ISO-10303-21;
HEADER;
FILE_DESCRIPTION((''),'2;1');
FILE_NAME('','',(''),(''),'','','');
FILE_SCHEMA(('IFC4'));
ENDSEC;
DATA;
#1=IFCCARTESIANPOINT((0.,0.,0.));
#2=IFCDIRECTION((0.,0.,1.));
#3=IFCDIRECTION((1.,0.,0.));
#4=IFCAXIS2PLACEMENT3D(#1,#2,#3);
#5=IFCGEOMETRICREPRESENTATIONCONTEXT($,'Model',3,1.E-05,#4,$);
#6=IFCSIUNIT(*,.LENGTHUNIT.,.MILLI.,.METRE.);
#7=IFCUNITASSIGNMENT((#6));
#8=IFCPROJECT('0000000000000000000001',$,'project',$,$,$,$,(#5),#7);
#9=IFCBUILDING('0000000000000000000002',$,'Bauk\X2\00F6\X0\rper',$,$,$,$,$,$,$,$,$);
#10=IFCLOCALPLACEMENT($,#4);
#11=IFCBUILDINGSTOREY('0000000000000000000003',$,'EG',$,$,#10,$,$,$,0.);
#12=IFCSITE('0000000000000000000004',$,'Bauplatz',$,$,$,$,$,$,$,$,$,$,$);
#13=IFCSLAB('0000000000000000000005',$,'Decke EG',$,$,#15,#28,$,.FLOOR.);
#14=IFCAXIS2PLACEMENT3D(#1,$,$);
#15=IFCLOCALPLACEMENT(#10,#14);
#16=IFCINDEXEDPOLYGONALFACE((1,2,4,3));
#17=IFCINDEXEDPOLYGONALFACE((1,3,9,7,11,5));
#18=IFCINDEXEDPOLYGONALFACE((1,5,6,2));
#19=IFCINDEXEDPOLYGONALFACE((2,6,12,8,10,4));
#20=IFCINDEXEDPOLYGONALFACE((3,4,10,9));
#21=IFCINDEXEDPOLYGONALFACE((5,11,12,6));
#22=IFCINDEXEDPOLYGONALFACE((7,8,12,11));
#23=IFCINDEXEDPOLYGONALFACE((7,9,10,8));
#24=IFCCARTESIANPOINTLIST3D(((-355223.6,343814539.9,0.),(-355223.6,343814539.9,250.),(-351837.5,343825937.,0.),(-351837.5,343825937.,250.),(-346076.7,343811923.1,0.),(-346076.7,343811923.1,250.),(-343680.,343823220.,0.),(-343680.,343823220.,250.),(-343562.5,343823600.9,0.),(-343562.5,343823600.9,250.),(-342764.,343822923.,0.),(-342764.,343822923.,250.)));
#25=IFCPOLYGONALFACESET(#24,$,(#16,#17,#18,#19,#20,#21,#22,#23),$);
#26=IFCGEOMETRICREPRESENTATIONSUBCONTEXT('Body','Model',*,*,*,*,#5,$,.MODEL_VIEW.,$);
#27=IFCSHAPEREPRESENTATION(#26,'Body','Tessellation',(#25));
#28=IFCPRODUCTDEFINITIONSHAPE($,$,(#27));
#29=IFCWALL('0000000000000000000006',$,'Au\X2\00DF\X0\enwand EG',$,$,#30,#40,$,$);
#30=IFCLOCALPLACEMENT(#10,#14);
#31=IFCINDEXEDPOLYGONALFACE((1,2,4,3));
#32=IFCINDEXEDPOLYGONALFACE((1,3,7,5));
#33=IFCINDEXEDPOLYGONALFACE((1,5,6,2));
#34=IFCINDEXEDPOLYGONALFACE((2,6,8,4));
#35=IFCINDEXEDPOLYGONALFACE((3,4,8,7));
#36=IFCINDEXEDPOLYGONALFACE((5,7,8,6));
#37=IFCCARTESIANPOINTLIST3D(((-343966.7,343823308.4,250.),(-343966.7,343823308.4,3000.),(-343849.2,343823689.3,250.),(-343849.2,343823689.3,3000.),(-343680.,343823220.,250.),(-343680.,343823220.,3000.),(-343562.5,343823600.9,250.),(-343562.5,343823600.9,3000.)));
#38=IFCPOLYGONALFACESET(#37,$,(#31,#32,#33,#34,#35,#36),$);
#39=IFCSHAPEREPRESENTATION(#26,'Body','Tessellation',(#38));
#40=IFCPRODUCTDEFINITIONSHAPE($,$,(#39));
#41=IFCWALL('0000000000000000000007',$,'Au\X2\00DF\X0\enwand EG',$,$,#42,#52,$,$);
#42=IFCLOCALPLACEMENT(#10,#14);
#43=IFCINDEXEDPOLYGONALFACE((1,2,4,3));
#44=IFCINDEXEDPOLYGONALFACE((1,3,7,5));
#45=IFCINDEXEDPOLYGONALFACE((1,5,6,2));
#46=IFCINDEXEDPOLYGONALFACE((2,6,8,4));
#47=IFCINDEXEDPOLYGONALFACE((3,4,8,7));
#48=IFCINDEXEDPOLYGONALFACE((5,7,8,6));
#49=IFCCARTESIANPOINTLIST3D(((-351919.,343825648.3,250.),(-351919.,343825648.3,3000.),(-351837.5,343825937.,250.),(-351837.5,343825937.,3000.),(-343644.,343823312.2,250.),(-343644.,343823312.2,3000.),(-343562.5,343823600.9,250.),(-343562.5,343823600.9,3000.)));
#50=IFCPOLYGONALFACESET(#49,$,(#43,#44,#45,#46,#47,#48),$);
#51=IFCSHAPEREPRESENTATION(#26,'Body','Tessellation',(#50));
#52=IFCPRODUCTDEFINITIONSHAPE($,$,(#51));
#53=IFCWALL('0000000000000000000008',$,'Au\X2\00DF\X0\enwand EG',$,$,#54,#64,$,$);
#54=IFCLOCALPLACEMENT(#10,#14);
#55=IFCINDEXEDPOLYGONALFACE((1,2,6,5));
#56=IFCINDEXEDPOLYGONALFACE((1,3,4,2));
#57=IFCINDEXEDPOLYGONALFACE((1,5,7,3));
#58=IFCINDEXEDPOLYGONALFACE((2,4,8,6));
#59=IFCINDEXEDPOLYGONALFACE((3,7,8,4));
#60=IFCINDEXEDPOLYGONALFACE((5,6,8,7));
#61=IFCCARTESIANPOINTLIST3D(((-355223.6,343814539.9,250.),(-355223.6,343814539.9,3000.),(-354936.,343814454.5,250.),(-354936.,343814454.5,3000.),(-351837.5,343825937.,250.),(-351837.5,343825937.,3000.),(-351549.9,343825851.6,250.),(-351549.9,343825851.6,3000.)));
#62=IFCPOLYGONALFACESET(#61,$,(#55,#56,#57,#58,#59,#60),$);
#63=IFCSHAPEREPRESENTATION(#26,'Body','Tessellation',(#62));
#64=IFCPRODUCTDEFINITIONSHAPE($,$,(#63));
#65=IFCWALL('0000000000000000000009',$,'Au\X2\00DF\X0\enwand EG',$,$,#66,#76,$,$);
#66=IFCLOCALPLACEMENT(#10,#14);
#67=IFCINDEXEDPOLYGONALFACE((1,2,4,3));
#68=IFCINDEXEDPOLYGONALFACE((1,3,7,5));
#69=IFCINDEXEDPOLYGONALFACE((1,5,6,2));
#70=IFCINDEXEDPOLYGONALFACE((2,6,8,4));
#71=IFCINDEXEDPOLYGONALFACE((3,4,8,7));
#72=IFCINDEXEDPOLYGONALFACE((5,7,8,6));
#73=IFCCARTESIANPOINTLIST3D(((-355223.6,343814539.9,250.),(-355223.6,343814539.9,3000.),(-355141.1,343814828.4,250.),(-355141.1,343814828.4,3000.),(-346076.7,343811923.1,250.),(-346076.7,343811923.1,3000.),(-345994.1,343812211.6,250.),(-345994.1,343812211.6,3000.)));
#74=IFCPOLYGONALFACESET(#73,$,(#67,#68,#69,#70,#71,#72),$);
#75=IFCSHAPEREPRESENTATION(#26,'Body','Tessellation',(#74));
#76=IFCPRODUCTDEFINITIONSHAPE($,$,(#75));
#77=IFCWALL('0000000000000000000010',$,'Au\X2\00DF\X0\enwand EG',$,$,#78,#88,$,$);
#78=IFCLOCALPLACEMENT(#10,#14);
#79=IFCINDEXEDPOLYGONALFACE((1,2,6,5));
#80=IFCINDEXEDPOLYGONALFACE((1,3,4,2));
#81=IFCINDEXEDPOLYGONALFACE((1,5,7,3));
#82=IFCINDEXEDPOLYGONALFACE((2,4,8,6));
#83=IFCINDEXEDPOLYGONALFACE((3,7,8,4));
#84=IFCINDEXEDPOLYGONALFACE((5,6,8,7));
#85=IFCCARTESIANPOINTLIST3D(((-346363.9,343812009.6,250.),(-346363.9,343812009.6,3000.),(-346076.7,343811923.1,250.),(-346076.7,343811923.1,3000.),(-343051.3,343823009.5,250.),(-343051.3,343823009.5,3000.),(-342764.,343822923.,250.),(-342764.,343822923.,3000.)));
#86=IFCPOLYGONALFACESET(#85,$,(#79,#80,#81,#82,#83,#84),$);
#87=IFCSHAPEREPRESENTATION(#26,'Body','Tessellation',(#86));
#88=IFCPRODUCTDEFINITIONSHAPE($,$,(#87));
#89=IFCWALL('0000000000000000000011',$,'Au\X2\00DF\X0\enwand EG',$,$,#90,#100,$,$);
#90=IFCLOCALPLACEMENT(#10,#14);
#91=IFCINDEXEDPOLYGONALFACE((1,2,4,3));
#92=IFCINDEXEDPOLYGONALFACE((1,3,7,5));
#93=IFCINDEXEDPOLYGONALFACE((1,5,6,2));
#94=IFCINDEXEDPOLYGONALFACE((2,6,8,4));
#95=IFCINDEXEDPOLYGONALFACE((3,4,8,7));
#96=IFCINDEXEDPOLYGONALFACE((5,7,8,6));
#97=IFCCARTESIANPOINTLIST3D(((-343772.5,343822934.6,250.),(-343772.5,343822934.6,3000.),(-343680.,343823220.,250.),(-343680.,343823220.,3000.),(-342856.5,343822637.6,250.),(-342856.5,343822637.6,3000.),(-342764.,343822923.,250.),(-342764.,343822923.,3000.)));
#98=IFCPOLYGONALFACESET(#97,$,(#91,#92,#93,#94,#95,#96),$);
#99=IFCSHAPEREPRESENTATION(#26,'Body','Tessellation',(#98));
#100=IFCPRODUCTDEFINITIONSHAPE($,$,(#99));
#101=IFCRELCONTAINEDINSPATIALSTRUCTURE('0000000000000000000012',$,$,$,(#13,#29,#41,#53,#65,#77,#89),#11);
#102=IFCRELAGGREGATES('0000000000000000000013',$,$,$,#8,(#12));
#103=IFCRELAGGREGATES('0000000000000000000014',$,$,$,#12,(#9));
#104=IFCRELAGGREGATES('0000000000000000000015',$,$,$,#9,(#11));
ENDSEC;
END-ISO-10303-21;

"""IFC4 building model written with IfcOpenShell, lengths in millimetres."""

from ifc_helpers import new_model, si_unit, frame, origin_with_axes, place, context, subcontext, project, spatial, indexed_curve, outline, extrude, element, save


model = new_model("IFC4")

# Units and contexts
model_context = context("Model", 3, precision=1e-05, world=origin_with_axes())
body_context = subcontext(model_context, "Body", "Model", "MODEL_VIEW")
ifc_project = project(units=[si_unit("LENGTHUNIT", "METRE", prefix="MILLI")], contexts=[model_context])

# Site, building, storey
site = spatial("IfcSite", under=ifc_project, Name="Bauplatz")
building = spatial("IfcBuilding", under=site, Name="Baukörper")
storey_placement = place(None, origin_with_axes())
storey = spatial("IfcBuildingStorey", under=building, at=storey_placement, Name="EG", Elevation=0.0)

# Slab
slab_placement = place(storey_placement, origin_with_axes())
element("IfcSlab", 1, at=slab_placement, inside=storey, Name="Decke EG", PredefinedType="FLOOR", context=body_context, shape_type="SweptSolid", body=[
    extrude(outline(indexed_curve([(-343680.0, 343823220.0), (-342764.0, 343822923.0), (-346076.7, 343811923.1), (-355223.6, 343814539.9), (-351837.5, 343825937.0), (-343562.5, 343823600.9)])), None, (0.0, 0.0, 1.0), 250.0),
])

# Walls
wall_1_placement = place(storey_placement, frame((-343680.0, 343823220.0, 250.0), z_axis=(0.0, 0.0, 1.0), x_axis=(0.294713, 0.955586, 0.0)))
element("IfcWall", 2, at=wall_1_placement, inside=storey, Name="Außenwand EG", context=body_context, shape_type="SweptSolid", body=[
    extrude(outline(indexed_curve([(0.0, 0.0), (0.0, 300.0), (398.6, 300.0), (398.6, 0.0), (0.0, 0.0)], self_intersect=False)), origin_with_axes(), (0.0, 0.0, 1.0), 2750.0),
])
wall_2_placement = place(storey_placement, frame((-343562.5, 343823600.9, 250.0), z_axis=(0.0, 0.0, 1.0), x_axis=(-0.962385, 0.271691, 0.0)))
element("IfcWall", 3, at=wall_2_placement, inside=storey, Name="Außenwand EG", context=body_context, shape_type="SweptSolid", body=[
    extrude(outline(indexed_curve([(0.0, 0.0), (0.0, 300.0), (8598.4, 300.0), (8598.4, 0.0), (0.0, 0.0)], self_intersect=False)), origin_with_axes(), (0.0, 0.0, 1.0), 2750.0),
])
wall_3_placement = place(storey_placement, frame((-351837.5, 343825937.0, 250.0), z_axis=(0.0, 0.0, 1.0), x_axis=(-0.284796, -0.958588, 0.0)))
element("IfcWall", 4, at=wall_3_placement, inside=storey, Name="Außenwand EG", context=body_context, shape_type="SweptSolid", body=[
    extrude(outline(indexed_curve([(0.0, 0.0), (0.0, 300.0), (11889.4, 300.0), (11889.4, 0.0), (0.0, 0.0)], self_intersect=False)), origin_with_axes(), (0.0, 0.0, 1.0), 2750.0),
])
wall_4_placement = place(storey_placement, frame((-355223.6, 343814539.9, 250.0), z_axis=(0.0, 0.0, 1.0), x_axis=(0.96143, -0.275051, 0.0)))
element("IfcWall", 5, at=wall_4_placement, inside=storey, Name="Außenwand EG", context=body_context, shape_type="SweptSolid", body=[
    extrude(outline(indexed_curve([(0.0, 0.0), (0.0, 300.0), (9513.9, 300.0), (9513.9, 0.0), (0.0, 0.0)], self_intersect=False)), origin_with_axes(), (0.0, 0.0, 1.0), 2750.0),
])
wall_5_placement = place(storey_placement, frame((-346076.7, 343811923.1, 250.0), z_axis=(0.0, 0.0, 1.0), x_axis=(0.288362, 0.957521, 0.0)))
element("IfcWall", 6, at=wall_5_placement, inside=storey, Name="Außenwand EG", context=body_context, shape_type="SweptSolid", body=[
    extrude(outline(indexed_curve([(0.0, 0.0), (0.0, 300.0), (11487.9, 300.0), (11487.9, 0.0), (0.0, 0.0)], self_intersect=False)), origin_with_axes(), (0.0, 0.0, 1.0), 2750.0),
])
wall_6_placement = place(storey_placement, frame((-342764.0, 343822923.0, 250.0), z_axis=(0.0, 0.0, 1.0), x_axis=(-0.951248, 0.308429, 0.0)))
element("IfcWall", 7, at=wall_6_placement, inside=storey, Name="Außenwand EG", context=body_context, shape_type="SweptSolid", body=[
    extrude(outline(indexed_curve([(0.0, 0.0), (0.0, 300.0), (962.9, 300.0), (962.9, 0.0), (0.0, 0.0)], self_intersect=False)), origin_with_axes(), (0.0, 0.0, 1.0), 2750.0),
])

save(model, "model.ifc")
